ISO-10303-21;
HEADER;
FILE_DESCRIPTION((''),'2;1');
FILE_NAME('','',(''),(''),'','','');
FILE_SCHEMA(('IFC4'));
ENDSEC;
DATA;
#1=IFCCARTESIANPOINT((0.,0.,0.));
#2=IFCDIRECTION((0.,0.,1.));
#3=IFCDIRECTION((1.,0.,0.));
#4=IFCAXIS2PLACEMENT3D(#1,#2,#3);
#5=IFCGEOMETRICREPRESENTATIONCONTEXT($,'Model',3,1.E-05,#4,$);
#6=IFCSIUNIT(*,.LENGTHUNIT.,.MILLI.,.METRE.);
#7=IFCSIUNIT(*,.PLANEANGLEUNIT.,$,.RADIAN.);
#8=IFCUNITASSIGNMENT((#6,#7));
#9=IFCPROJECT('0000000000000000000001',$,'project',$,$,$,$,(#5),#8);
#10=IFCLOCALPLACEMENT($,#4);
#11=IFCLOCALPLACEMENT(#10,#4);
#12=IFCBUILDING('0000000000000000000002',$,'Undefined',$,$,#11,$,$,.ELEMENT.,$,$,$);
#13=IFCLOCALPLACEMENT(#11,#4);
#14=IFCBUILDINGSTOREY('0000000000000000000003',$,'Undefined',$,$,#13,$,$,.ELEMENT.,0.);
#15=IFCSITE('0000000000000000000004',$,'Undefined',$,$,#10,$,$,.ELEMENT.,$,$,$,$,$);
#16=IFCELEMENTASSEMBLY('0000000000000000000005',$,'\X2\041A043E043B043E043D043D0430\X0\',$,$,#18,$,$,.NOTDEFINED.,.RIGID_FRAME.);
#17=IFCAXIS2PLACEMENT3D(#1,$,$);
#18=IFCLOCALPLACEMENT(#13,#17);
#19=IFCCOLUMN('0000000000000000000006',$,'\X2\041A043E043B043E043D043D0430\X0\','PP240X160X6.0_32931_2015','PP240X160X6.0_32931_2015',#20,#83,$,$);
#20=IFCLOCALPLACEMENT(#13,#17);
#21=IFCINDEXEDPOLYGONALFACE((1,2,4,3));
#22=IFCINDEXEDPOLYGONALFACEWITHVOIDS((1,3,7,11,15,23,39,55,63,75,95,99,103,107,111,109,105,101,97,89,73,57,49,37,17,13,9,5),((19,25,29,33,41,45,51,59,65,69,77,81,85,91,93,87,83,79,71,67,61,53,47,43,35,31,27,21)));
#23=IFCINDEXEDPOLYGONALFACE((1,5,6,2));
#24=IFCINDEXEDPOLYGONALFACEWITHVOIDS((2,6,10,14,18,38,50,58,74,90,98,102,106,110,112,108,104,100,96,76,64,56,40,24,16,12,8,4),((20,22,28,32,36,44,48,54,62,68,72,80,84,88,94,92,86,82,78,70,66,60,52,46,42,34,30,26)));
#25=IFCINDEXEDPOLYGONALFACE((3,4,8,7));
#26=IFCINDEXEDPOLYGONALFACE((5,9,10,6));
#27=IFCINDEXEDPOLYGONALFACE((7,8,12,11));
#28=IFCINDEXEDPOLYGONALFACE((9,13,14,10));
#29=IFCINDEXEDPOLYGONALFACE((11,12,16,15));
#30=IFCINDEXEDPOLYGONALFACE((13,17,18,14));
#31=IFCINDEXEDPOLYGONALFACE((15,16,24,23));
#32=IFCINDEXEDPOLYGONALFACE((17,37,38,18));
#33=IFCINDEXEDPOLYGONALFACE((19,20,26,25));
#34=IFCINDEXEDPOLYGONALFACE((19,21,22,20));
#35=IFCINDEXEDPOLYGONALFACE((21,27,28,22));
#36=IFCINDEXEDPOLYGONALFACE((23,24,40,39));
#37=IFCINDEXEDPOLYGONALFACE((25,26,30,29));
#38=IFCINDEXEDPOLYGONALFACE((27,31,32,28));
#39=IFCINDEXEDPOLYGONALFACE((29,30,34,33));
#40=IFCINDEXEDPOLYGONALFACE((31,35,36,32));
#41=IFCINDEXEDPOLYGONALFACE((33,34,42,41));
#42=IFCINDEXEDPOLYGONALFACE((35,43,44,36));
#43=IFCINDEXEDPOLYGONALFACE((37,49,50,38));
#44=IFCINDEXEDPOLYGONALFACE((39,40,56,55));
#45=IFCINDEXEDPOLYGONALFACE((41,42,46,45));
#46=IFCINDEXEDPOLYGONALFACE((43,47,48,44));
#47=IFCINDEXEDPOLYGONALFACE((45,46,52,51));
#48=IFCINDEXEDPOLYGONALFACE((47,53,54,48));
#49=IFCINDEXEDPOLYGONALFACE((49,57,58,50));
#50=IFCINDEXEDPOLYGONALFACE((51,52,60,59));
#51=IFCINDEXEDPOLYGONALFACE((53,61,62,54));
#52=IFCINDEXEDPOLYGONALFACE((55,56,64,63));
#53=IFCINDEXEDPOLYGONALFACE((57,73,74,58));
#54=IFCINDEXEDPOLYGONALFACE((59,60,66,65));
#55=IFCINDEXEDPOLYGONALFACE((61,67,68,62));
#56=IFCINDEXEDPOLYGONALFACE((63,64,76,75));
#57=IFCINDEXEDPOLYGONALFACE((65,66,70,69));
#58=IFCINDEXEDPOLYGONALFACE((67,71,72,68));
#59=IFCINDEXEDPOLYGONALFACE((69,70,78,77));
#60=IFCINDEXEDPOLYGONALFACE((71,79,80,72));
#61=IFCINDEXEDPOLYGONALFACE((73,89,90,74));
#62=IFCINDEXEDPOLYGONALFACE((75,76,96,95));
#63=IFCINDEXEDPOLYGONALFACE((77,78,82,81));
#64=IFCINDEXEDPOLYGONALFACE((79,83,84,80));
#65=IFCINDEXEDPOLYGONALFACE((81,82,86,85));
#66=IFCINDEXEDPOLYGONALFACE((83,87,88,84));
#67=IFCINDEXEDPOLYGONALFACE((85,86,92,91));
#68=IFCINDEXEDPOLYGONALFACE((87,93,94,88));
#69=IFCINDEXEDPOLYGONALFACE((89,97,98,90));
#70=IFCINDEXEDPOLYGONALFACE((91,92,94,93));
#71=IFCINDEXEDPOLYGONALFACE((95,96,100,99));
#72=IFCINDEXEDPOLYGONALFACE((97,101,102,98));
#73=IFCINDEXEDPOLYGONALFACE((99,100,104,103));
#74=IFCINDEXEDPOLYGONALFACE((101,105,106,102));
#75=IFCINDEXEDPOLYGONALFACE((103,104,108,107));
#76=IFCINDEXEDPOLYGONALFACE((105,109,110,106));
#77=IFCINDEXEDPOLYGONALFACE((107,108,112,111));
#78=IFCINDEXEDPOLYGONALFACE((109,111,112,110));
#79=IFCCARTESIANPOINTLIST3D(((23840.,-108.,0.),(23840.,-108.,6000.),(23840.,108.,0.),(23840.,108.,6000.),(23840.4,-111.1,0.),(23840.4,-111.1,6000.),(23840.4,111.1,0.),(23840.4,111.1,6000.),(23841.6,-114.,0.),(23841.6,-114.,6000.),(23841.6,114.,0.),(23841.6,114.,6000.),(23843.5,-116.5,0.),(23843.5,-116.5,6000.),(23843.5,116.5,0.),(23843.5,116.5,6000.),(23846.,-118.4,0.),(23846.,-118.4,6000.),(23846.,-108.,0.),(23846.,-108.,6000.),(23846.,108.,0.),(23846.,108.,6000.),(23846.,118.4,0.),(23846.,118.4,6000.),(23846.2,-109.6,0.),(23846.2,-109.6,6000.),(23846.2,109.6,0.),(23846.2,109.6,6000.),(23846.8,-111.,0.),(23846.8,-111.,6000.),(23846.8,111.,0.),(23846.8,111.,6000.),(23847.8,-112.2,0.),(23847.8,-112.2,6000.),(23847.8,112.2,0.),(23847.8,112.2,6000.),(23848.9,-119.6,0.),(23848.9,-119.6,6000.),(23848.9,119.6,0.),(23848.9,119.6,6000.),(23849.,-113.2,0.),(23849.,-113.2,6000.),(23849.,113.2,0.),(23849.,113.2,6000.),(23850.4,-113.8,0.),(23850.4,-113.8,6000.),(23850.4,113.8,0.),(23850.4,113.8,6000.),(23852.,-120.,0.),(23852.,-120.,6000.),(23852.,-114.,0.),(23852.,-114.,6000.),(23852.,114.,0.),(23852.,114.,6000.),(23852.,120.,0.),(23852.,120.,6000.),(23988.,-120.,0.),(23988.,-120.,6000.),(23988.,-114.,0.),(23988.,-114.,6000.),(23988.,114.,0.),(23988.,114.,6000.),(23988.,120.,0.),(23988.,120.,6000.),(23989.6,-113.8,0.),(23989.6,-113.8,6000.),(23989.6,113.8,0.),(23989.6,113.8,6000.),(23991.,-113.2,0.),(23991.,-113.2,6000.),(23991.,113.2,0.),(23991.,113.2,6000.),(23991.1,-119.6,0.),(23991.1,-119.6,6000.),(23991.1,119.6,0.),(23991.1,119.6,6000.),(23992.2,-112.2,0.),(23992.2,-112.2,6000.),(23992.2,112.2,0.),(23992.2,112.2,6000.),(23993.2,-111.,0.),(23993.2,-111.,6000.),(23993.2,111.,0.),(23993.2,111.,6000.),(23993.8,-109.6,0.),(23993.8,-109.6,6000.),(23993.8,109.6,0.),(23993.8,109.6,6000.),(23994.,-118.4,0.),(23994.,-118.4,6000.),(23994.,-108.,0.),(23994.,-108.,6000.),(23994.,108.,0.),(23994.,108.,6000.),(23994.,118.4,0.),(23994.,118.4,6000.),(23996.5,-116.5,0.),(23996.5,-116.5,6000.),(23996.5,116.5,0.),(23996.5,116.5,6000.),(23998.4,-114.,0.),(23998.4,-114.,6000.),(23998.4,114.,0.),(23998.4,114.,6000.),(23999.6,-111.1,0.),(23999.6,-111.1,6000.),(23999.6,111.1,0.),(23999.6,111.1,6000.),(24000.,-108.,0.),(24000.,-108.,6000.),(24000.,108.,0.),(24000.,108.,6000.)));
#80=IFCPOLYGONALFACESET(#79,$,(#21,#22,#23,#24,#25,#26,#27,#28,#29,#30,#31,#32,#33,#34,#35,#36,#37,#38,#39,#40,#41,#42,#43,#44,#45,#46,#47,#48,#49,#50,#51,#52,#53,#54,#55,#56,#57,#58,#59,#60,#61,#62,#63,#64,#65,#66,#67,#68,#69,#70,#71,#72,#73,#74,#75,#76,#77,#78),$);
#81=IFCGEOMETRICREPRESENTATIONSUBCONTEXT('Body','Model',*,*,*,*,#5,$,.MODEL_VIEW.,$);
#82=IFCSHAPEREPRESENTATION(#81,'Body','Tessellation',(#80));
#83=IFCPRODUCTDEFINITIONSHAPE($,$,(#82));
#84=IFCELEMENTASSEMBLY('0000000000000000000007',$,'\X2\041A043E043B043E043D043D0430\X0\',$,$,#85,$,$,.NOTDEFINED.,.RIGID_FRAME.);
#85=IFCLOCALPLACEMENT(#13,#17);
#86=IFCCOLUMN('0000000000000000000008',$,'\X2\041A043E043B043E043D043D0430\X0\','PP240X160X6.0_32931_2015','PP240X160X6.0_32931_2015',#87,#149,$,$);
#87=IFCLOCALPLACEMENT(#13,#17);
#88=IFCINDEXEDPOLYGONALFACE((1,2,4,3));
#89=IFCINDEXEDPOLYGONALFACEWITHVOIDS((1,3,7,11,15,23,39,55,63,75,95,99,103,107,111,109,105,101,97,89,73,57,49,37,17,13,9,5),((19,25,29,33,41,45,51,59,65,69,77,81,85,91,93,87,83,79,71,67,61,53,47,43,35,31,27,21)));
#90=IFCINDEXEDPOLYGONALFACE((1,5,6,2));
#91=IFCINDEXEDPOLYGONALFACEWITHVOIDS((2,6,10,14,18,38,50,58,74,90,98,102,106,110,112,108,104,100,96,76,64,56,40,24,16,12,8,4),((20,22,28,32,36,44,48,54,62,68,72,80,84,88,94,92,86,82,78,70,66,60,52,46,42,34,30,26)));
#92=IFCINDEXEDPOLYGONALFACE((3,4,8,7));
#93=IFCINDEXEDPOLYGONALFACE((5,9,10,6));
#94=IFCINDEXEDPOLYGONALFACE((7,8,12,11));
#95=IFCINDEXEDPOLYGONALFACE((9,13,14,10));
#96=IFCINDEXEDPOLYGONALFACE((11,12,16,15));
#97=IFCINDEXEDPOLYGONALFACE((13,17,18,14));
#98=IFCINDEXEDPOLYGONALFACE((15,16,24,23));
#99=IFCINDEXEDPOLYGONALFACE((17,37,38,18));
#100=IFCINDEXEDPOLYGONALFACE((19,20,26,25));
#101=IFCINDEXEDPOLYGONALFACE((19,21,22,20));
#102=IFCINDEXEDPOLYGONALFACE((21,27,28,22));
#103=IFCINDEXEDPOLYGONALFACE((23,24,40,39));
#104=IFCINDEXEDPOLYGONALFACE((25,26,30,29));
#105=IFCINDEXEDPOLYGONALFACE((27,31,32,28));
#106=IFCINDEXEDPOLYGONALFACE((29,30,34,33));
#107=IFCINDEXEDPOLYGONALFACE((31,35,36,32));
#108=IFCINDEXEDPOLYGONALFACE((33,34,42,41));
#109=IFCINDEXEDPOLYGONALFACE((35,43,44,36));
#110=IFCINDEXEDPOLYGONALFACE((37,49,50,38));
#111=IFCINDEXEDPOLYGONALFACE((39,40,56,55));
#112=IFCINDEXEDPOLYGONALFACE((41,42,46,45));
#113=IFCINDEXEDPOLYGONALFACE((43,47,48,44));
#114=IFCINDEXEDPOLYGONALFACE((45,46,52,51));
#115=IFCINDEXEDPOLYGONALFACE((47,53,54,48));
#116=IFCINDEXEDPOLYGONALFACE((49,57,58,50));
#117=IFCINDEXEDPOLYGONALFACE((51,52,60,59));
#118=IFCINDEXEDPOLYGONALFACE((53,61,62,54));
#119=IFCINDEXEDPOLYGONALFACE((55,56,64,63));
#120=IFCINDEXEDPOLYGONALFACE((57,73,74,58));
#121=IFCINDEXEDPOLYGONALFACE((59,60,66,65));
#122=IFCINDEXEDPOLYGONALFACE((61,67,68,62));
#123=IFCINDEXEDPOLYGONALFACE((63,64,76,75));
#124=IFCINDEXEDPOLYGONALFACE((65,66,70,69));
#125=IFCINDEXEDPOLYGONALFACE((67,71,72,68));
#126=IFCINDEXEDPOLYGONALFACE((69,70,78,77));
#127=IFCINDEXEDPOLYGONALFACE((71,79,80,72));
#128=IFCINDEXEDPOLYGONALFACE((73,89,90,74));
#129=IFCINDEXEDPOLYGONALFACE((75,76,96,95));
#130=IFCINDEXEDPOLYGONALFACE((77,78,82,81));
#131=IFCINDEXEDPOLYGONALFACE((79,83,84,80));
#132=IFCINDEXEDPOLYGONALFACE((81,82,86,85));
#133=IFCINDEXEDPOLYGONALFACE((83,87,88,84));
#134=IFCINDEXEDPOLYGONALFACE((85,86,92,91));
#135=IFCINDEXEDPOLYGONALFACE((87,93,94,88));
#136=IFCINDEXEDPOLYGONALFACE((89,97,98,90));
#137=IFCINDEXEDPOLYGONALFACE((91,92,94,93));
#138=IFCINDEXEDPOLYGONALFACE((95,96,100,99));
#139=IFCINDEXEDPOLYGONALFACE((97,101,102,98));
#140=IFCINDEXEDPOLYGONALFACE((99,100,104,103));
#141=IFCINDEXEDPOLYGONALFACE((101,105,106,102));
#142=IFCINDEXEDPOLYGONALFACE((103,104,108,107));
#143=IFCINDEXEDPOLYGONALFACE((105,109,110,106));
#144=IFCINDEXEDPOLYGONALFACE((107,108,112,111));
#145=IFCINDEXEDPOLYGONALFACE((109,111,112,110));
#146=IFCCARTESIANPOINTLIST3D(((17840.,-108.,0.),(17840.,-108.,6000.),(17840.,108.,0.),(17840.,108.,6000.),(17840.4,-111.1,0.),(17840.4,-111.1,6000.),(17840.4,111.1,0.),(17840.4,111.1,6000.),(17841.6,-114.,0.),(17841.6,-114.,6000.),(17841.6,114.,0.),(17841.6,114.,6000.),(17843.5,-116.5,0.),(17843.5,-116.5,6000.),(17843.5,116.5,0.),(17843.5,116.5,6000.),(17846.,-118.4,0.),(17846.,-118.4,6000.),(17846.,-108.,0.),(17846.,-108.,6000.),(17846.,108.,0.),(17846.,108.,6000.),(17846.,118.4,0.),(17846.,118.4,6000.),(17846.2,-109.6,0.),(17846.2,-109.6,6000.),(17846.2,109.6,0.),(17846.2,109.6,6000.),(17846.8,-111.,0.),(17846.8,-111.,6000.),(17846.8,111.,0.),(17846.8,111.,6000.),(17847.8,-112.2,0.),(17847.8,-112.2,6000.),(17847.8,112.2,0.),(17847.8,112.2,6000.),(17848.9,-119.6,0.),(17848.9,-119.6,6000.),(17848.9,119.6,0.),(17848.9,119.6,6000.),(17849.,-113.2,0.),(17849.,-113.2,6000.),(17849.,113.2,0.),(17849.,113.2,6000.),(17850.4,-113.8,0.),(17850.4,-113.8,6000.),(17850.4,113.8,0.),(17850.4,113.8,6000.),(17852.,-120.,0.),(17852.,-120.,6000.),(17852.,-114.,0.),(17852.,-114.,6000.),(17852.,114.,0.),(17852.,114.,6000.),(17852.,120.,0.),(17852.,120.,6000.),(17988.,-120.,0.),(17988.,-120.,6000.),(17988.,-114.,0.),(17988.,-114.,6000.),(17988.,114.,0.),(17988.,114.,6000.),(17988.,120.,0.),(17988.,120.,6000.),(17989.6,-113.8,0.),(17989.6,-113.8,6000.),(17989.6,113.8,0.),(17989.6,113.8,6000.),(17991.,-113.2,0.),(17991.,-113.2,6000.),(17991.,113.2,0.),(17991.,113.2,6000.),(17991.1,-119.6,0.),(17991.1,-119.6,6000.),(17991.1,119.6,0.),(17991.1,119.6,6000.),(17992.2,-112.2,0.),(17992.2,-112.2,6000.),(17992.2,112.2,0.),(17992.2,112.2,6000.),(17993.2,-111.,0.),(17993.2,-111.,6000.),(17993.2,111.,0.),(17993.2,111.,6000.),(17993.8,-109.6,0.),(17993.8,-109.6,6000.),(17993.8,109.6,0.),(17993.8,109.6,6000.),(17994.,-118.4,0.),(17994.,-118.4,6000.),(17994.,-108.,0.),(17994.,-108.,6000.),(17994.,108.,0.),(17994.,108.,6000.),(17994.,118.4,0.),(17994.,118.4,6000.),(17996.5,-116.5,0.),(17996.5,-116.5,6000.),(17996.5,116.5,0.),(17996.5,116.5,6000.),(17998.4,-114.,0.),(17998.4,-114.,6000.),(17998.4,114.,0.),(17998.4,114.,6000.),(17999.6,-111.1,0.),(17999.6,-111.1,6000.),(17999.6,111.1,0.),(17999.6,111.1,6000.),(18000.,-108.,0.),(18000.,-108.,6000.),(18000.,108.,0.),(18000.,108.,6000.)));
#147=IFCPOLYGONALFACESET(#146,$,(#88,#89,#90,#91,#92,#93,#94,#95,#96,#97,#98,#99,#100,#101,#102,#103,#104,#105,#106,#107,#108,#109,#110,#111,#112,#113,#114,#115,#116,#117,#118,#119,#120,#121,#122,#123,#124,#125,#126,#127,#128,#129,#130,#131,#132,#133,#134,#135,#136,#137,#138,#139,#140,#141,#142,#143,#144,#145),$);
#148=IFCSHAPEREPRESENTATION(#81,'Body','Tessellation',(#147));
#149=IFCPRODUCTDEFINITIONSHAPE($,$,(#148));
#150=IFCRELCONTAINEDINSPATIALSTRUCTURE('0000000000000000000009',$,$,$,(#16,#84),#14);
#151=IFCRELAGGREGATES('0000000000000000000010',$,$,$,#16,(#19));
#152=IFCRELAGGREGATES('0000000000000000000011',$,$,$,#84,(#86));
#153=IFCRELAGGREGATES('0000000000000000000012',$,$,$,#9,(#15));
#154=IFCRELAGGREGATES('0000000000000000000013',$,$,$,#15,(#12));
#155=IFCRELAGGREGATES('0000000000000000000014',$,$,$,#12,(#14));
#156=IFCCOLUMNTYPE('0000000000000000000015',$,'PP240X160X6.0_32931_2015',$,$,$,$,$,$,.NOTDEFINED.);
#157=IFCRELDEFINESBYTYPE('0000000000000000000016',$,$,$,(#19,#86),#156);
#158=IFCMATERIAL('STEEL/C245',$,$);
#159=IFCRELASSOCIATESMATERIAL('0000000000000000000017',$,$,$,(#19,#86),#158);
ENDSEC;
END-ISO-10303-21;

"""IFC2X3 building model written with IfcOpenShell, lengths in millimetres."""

from ifc_helpers import new_model, si_unit, frame, origin_with_axes, origin_2d_with_axis, place, context, subcontext, project, spatial, hollow_rectangle, extrude, material, type_object, element, aggregate, save


model = new_model("IFC2X3")

# Units and contexts
model_context = context("Model", 3, precision=1e-05, world=origin_with_axes())
body_context = subcontext(model_context, "Body", "Model", "MODEL_VIEW")
ifc_project = project(units=[si_unit("LENGTHUNIT", "METRE", prefix="MILLI"), si_unit("PLANEANGLEUNIT", "RADIAN")], contexts=[model_context])

# Site, building, storey
site_placement = place(None, origin_with_axes())
site = spatial("IfcSite", under=ifc_project, at=site_placement, Name="Undefined", CompositionType="ELEMENT")
building_placement = place(site_placement, origin_with_axes())
building = spatial("IfcBuilding", under=site, at=building_placement, Name="Undefined", CompositionType="ELEMENT")
storey_placement = place(building_placement, origin_with_axes())
storey = spatial("IfcBuildingStorey", under=building, at=storey_placement, Name="Undefined", CompositionType="ELEMENT", Elevation=0.0)

# Element assemblies, columns
assembly_1_placement = place(storey_placement, origin_with_axes())
assembly_1 = element("IfcElementAssembly", 1, at=assembly_1_placement, inside=storey, Name="Колонна", AssemblyPlace="NOTDEFINED", PredefinedType="RIGID_FRAME")
ifc_material = material(Name="STEEL/C245")
column_type_1 = type_object("IfcColumnType", Name="PP240X160X6.0_32931_2015", PredefinedType="NOTDEFINED")
column_1_placement = place(assembly_1_placement, frame((23920.0, 0.0, 0.0), z_axis=(0.0, 0.0, 1.0), x_axis=(0.0, 1.0, 0.0)))
column_1 = element("IfcColumn", 2, at=column_1_placement, type_object=column_type_1, material=ifc_material, Name="Колонна", Description="PP240X160X6.0_32931_2015", ObjectType="PP240X160X6.0_32931_2015", context=body_context, shape_type="SweptSolid", body=[
    extrude(hollow_rectangle(XDim=160.0, YDim=240.0, WallThickness=6.0, InnerFilletRadius=6.0, OuterFilletRadius=12.0, at=origin_2d_with_axis()), frame((0.0, 0.0, 6000.0), z_axis=(0.0, 0.0, -1.0), x_axis=(0.0, 1.0, 0.0)), (0.0, 0.0, 1.0), 6000.0),
])
aggregate(assembly_1, [column_1])
assembly_2_placement = place(storey_placement, origin_with_axes())
assembly_2 = element("IfcElementAssembly", 3, at=assembly_2_placement, inside=storey, Name="Колонна", AssemblyPlace="NOTDEFINED", PredefinedType="RIGID_FRAME")
column_2_placement = place(assembly_2_placement, frame((17920.0, 0.0, 0.0), z_axis=(0.0, 0.0, 1.0), x_axis=(0.0, 1.0, 0.0)))
column_2 = element("IfcColumn", 4, at=column_2_placement, type_object=column_type_1, material=ifc_material, Name="Колонна", Description="PP240X160X6.0_32931_2015", ObjectType="PP240X160X6.0_32931_2015", context=body_context, shape_type="SweptSolid", body=[
    extrude(hollow_rectangle(XDim=160.0, YDim=240.0, WallThickness=6.0, InnerFilletRadius=6.0, OuterFilletRadius=12.0, at=origin_2d_with_axis()), frame((0.0, 0.0, 6000.0), z_axis=(0.0, 0.0, -1.0), x_axis=(0.0, 1.0, 0.0)), (0.0, 0.0, 1.0), 6000.0),
])
aggregate(assembly_2, [column_2])

save(model, "model.ifc")
